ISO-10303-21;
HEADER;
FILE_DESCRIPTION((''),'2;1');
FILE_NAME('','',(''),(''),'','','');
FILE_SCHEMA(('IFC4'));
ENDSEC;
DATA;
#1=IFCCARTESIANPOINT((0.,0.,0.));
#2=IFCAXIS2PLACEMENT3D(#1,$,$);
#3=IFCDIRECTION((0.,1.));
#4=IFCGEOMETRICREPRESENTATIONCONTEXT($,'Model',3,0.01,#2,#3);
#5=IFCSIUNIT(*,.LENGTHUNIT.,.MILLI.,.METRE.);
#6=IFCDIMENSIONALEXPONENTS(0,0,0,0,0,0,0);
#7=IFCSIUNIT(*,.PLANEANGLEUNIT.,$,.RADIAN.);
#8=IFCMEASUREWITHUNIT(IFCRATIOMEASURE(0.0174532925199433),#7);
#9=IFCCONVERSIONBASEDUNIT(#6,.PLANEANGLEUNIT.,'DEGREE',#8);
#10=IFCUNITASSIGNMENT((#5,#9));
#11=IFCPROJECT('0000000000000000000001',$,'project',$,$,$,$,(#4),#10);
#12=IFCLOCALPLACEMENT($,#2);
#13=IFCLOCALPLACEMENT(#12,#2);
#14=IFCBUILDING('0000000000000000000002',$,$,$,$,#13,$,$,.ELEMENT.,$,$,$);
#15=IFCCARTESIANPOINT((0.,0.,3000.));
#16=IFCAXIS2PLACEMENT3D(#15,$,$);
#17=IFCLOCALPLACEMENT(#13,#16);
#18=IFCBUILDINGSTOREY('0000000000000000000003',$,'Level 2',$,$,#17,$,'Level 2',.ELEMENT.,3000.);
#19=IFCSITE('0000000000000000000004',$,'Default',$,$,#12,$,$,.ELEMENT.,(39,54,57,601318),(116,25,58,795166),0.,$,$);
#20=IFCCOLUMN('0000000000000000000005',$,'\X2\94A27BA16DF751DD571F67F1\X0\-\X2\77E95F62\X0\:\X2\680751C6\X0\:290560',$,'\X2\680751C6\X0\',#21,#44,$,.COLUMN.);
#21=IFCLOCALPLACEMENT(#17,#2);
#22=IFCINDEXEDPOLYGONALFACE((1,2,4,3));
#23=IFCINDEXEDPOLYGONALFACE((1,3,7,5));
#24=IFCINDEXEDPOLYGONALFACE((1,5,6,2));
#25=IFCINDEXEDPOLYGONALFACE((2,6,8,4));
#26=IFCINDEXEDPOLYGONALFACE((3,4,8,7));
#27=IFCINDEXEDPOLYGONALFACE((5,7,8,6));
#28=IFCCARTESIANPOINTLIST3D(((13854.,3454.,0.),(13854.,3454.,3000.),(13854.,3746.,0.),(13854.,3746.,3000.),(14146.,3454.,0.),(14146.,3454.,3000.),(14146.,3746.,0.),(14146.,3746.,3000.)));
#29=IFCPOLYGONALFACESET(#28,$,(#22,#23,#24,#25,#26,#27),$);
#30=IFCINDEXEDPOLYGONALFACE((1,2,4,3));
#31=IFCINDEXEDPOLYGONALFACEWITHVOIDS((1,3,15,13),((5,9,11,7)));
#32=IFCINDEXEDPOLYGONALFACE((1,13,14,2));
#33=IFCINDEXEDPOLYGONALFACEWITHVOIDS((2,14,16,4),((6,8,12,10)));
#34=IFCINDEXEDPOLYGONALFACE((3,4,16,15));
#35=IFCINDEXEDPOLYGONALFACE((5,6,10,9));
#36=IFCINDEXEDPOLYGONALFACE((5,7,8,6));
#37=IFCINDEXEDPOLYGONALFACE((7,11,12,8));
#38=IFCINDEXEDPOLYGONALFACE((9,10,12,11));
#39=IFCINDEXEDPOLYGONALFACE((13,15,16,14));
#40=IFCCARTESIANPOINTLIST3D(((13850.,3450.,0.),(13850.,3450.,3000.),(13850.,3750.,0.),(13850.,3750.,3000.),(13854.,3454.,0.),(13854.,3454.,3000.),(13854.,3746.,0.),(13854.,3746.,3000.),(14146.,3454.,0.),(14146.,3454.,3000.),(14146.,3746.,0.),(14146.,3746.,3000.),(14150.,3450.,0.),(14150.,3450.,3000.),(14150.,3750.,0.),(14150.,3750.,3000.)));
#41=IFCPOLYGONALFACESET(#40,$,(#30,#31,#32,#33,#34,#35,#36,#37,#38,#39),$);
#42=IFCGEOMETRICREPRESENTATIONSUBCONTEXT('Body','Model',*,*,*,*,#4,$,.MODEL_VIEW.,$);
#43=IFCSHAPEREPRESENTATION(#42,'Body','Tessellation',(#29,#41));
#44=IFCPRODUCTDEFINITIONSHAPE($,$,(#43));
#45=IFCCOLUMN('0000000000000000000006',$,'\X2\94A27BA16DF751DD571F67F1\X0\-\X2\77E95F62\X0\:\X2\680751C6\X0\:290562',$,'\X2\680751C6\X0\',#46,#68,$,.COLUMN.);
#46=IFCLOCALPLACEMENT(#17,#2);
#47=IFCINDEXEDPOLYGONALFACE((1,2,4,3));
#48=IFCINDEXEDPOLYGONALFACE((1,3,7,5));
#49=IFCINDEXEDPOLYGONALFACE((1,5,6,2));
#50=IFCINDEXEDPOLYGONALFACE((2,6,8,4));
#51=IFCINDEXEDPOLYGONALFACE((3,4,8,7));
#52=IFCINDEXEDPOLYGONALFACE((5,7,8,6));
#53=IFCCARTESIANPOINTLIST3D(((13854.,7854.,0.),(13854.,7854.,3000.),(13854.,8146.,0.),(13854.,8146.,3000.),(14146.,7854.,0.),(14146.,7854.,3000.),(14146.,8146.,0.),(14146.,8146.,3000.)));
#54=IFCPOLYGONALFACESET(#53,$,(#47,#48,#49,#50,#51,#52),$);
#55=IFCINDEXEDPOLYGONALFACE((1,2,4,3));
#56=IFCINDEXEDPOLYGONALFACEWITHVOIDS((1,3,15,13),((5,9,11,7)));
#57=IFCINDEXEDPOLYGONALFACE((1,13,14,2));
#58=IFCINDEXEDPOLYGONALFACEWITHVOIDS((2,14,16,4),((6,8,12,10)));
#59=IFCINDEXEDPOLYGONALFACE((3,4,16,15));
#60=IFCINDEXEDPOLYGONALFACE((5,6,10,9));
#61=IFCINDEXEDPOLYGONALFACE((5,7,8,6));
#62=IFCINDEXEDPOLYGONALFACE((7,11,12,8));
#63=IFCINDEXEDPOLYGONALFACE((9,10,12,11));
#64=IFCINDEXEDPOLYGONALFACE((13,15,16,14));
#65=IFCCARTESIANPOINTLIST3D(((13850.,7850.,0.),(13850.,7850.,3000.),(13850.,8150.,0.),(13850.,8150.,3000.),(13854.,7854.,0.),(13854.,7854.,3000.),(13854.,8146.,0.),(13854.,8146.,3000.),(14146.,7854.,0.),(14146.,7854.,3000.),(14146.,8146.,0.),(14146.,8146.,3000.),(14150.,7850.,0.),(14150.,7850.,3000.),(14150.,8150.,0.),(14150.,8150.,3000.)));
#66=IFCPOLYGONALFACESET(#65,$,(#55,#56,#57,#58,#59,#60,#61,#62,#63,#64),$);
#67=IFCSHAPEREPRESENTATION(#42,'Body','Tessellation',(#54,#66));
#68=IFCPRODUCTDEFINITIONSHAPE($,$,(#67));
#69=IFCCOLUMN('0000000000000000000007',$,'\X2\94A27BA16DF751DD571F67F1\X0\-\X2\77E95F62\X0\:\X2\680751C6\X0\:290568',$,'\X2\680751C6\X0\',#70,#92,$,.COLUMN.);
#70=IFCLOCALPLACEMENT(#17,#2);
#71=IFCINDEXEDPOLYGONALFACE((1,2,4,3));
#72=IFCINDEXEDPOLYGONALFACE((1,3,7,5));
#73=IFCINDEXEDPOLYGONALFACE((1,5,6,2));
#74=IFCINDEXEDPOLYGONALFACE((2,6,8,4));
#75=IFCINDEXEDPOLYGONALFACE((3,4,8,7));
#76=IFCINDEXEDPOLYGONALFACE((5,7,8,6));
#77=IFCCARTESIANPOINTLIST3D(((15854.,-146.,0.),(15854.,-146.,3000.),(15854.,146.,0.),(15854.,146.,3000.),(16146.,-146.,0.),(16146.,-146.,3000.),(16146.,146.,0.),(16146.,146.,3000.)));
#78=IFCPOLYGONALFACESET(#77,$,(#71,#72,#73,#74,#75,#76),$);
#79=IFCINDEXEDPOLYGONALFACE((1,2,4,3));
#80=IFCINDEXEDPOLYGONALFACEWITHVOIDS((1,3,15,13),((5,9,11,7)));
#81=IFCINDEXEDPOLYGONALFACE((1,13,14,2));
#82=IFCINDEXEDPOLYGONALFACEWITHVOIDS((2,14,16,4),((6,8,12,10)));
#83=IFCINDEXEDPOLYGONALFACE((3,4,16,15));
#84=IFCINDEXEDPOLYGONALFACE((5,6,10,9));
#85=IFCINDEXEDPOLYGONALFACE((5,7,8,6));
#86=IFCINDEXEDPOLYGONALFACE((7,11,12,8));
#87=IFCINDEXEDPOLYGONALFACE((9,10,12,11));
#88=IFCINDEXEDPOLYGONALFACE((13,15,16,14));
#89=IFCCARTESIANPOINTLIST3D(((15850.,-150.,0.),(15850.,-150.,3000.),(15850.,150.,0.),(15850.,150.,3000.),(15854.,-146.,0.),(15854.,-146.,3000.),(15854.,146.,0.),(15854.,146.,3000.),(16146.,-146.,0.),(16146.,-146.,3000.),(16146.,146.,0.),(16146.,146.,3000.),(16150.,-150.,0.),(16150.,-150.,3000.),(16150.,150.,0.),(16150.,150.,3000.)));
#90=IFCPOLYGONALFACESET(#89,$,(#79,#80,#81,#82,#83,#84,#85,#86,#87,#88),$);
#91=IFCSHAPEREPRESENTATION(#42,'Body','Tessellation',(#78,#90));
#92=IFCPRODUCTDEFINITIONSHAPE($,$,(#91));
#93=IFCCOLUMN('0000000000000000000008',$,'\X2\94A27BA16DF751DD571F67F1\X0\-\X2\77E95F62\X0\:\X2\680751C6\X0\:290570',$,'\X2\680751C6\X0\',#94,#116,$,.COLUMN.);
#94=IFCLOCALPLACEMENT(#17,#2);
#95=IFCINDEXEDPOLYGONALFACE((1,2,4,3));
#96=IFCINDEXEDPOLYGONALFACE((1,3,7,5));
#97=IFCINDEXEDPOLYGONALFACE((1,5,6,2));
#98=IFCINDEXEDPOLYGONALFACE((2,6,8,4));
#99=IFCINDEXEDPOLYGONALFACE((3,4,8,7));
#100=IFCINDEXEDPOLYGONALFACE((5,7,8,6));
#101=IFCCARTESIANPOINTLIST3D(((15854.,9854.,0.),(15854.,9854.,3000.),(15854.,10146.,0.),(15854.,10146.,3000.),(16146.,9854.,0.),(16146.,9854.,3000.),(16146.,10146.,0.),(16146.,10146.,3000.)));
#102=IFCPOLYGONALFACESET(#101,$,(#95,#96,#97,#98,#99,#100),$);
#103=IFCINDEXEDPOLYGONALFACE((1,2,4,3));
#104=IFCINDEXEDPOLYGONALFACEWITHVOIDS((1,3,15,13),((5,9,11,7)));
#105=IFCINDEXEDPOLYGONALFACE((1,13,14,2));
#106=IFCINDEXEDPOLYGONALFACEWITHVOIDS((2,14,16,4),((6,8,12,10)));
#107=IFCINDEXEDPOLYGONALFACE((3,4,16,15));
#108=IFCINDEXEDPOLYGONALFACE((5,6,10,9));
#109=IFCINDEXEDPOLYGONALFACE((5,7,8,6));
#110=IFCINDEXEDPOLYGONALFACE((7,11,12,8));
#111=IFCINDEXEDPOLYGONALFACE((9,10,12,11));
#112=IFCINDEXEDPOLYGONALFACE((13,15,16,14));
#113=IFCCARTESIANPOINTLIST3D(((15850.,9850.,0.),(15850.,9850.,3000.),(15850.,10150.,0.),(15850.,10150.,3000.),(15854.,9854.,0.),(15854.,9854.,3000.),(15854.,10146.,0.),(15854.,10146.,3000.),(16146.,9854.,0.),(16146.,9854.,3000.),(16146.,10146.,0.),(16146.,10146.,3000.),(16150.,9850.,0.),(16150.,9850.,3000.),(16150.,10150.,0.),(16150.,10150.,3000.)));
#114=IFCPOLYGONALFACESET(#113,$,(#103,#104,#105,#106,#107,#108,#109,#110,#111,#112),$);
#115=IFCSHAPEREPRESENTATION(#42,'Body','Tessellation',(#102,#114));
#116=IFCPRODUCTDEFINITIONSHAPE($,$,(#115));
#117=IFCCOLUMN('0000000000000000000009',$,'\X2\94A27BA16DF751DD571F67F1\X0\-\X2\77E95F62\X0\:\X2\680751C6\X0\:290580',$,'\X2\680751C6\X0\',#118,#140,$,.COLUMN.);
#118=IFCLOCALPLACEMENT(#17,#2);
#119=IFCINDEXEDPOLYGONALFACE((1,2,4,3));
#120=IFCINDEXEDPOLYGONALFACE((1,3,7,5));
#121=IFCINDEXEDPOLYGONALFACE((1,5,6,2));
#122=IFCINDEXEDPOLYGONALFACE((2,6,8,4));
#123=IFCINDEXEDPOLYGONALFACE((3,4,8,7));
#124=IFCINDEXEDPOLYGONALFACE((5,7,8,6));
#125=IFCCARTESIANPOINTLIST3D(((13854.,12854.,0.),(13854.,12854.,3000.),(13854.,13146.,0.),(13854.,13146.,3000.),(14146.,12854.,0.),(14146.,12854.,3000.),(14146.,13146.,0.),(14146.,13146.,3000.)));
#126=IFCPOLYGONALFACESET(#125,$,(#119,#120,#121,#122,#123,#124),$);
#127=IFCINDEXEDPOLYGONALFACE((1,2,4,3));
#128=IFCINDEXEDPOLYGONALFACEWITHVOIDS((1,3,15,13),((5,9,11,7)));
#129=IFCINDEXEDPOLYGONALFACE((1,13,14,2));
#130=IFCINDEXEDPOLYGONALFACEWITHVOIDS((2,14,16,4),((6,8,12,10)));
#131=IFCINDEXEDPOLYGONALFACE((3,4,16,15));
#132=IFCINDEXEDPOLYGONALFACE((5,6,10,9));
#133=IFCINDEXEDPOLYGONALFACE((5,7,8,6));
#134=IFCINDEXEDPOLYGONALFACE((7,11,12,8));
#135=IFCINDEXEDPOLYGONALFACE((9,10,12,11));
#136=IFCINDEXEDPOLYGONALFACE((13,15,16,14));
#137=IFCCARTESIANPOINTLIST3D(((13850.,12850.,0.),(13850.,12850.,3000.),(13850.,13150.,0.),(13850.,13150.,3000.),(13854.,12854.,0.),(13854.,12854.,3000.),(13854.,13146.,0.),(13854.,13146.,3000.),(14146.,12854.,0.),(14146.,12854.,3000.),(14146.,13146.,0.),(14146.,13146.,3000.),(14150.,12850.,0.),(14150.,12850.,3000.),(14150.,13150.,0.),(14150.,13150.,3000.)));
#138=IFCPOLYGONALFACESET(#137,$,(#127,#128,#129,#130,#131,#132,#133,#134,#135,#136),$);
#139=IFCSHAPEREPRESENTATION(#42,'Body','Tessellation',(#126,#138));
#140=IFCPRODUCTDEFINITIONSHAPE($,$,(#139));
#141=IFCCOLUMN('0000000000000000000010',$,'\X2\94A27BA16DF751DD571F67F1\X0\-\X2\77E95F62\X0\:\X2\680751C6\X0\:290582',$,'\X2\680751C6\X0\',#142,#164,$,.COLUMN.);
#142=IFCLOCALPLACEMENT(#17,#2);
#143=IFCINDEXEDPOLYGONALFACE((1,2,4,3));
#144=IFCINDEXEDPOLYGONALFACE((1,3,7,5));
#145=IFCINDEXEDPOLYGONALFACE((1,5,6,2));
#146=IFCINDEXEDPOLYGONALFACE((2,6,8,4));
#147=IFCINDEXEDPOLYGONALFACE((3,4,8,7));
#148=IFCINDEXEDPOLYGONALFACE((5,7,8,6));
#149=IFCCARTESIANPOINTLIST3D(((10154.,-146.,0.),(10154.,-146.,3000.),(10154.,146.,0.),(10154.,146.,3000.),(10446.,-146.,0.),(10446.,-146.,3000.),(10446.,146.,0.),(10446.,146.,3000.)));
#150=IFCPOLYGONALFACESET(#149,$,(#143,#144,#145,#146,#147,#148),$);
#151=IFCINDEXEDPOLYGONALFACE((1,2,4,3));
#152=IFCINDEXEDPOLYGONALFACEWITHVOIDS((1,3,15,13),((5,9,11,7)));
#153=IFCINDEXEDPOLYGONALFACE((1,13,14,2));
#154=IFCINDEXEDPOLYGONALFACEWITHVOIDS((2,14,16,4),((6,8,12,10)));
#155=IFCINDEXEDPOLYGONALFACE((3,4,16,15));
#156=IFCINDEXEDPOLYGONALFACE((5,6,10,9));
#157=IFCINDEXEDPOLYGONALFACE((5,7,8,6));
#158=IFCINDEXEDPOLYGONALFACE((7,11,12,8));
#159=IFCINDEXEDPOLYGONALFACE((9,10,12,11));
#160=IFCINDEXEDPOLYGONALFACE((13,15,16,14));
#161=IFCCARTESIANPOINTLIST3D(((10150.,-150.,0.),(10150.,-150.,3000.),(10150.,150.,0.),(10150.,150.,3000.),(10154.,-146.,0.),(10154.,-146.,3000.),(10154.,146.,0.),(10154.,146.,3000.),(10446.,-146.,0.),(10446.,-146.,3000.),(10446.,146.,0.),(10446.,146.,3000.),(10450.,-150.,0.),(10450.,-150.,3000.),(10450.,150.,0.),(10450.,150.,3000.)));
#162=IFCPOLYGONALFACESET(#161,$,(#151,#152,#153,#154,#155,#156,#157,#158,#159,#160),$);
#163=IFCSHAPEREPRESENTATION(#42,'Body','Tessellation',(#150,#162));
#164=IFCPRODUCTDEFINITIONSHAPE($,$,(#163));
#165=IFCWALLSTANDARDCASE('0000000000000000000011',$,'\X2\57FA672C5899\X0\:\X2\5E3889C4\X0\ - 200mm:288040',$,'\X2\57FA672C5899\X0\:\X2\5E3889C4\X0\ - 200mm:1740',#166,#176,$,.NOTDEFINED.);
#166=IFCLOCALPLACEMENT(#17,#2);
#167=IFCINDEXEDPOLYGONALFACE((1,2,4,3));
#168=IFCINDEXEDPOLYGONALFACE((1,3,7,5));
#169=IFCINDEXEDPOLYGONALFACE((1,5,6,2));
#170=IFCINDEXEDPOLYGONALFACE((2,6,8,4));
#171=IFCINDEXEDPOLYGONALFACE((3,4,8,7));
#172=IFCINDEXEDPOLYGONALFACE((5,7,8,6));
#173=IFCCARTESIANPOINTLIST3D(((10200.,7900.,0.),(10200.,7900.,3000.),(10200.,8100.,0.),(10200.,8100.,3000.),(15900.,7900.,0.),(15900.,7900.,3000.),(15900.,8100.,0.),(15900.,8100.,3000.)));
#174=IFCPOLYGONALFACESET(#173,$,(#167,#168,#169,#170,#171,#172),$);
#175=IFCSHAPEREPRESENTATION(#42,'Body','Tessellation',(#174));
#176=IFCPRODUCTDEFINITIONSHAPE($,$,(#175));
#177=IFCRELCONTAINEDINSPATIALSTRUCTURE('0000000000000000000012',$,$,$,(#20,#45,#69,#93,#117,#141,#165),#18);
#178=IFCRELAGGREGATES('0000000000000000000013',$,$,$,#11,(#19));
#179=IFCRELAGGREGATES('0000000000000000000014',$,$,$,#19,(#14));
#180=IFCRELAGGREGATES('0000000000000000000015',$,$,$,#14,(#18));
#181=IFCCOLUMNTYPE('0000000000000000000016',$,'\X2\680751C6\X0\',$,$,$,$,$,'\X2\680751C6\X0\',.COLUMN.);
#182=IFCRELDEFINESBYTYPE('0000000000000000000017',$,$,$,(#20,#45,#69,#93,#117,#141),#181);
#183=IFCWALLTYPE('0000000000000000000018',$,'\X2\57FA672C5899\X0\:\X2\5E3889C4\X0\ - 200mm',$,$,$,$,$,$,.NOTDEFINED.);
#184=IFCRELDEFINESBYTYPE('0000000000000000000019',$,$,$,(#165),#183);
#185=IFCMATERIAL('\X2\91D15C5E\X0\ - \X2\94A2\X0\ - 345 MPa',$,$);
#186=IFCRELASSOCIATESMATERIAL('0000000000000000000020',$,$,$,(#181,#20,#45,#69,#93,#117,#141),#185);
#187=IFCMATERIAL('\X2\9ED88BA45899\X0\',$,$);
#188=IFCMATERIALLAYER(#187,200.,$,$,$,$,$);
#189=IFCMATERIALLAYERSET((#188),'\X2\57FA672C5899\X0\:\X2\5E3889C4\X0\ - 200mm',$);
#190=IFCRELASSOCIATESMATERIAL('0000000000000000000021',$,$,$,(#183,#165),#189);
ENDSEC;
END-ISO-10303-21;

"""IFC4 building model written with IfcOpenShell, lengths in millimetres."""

from ifc_helpers import new_model, entity, si_unit, converted_unit, direction, frame, frame_2d, origin, origin_2d_with_axis, place, context, subcontext, project, spatial, polyline, rectangle, outline, extrude, source, transform, mapped, material, layer, layer_set, layer_usage, type_object, type_shapes, element, save


model = new_model("IFC4")

# Units and contexts
model_context = context("Model", 3, precision=0.01, world=origin(), true_north=direction((0.0, 1.0)))
body_context = subcontext(model_context, "Body", "Model", "MODEL_VIEW")
ifc_project = project(units=[si_unit("LENGTHUNIT", "METRE", prefix="MILLI"), converted_unit("PLANEANGLEUNIT", "DEGREE", entity("IfcRatioMeasure", 0.0174532925199433), si_unit("PLANEANGLEUNIT", "RADIAN"), dimensions=[0, 0, 0, 0, 0, 0, 0])], contexts=[model_context])

# Site, building, storey
site_placement = place(None, origin())
site = spatial("IfcSite", under=ifc_project, at=site_placement, Name="Default", CompositionType="ELEMENT", RefLatitude=(39, 54, 57, 601318), RefLongitude=(116, 25, 58, 795166), RefElevation=0.0)
building_placement = place(site_placement, origin())
building = spatial("IfcBuilding", under=site, at=building_placement, CompositionType="ELEMENT")
storey_placement = place(building_placement, frame((0.0, 0.0, 3000.0)))
storey = spatial("IfcBuildingStorey", under=building, at=storey_placement, Name="Level 2", LongName="Level 2", CompositionType="ELEMENT", Elevation=3000.0)

# Columns
ifc_material_1 = material(Name="金属 - 钢 - 345 MPa")
column_type = type_object("IfcColumnType", Name="标准", ElementType="标准", PredefinedType="COLUMN", material=ifc_material_1)
shared_shape_1 = source(origin(), body_context, "Body", "SweptSolid", [
    extrude(rectangle(XDim=292.0, YDim=292.0, at=origin_2d_with_axis()), frame((150.0, 150.0, 0.0), z_axis=(0.0, 0.0, 1.0), x_axis=(-1.0, 0.0, 0.0)), (0.0, 0.0, 1.0), 3000.0),
    extrude(outline(polyline([(-150.0, -150.0), (150.0, -150.0), (150.0, 150.0), (-150.0, 150.0), (-150.0, -150.0)]), holes=[polyline([(-146.0, -146.0), (-146.0, 146.0), (146.0, 146.0), (146.0, -146.0), (-146.0, -146.0)])]), frame((150.0, 150.0, 0.0), z_axis=(0.0, 0.0, 1.0), x_axis=(-1.0, 0.0, 0.0)), (0.0, 0.0, 1.0), 3000.0),
])
type_shapes(column_type, [shared_shape_1])
for number, where, name in (
    (1, (13850.0, 3450.0, 0.0), "钢管混凝土柱-矩形:标准:290560"),
    (2, (13850.0, 7850.0, 0.0), "钢管混凝土柱-矩形:标准:290562"),
    (3, (15850.0, -150.0, 0.0), "钢管混凝土柱-矩形:标准:290568"),
    (4, (15850.0, 9850.0, 0.0), "钢管混凝土柱-矩形:标准:290570"),
    (5, (13850.0, 12850.0, 0.0), "钢管混凝土柱-矩形:标准:290580"),
    (6, (10150.0, -150.0, 0.0), "钢管混凝土柱-矩形:标准:290582"),
):
    element("IfcColumn", number, at=place(storey_placement, frame(where)), inside=storey, type_object=column_type, material=ifc_material_1, Name=name, ObjectType="标准", PredefinedType="COLUMN", context=body_context, shape_type="MappedRepresentation", body=[
        mapped(shared_shape_1, transform((0.0, 0.0, 0.0), scale=1.0)),
    ])

# Wall
ifc_material_2 = material(Name="默认墙")
ifc_layer = layer(ifc_material_2, 200.0)
ifc_layer_set = layer_set([ifc_layer], Name="基本墙:常规 - 200mm")
ifc_layer_usage_1 = layer_usage(ifc_layer_set, "AXIS2", "NEGATIVE", 100.0)
wall_type = type_object("IfcWallType", Name="基本墙:常规 - 200mm", PredefinedType="NOTDEFINED", material=ifc_layer_set)
wall_1_placement = place(storey_placement, frame((10200.0, 8000.0, 0.0)))
element("IfcWallStandardCase", 7, at=wall_1_placement, inside=storey, type_object=wall_type, material=ifc_layer_usage_1, Name="基本墙:常规 - 200mm:288040", ObjectType="基本墙:常规 - 200mm:1740", PredefinedType="NOTDEFINED", context=body_context, shape_type="SweptSolid", body=[
    extrude(rectangle(XDim=5700.0, YDim=200.0, at=frame_2d((2850.0, 0.0), x_axis=(-1.0, 0.0))), origin(), (0.0, 0.0, 1.0), 3000.0),
])

save(model, "model.ifc")
